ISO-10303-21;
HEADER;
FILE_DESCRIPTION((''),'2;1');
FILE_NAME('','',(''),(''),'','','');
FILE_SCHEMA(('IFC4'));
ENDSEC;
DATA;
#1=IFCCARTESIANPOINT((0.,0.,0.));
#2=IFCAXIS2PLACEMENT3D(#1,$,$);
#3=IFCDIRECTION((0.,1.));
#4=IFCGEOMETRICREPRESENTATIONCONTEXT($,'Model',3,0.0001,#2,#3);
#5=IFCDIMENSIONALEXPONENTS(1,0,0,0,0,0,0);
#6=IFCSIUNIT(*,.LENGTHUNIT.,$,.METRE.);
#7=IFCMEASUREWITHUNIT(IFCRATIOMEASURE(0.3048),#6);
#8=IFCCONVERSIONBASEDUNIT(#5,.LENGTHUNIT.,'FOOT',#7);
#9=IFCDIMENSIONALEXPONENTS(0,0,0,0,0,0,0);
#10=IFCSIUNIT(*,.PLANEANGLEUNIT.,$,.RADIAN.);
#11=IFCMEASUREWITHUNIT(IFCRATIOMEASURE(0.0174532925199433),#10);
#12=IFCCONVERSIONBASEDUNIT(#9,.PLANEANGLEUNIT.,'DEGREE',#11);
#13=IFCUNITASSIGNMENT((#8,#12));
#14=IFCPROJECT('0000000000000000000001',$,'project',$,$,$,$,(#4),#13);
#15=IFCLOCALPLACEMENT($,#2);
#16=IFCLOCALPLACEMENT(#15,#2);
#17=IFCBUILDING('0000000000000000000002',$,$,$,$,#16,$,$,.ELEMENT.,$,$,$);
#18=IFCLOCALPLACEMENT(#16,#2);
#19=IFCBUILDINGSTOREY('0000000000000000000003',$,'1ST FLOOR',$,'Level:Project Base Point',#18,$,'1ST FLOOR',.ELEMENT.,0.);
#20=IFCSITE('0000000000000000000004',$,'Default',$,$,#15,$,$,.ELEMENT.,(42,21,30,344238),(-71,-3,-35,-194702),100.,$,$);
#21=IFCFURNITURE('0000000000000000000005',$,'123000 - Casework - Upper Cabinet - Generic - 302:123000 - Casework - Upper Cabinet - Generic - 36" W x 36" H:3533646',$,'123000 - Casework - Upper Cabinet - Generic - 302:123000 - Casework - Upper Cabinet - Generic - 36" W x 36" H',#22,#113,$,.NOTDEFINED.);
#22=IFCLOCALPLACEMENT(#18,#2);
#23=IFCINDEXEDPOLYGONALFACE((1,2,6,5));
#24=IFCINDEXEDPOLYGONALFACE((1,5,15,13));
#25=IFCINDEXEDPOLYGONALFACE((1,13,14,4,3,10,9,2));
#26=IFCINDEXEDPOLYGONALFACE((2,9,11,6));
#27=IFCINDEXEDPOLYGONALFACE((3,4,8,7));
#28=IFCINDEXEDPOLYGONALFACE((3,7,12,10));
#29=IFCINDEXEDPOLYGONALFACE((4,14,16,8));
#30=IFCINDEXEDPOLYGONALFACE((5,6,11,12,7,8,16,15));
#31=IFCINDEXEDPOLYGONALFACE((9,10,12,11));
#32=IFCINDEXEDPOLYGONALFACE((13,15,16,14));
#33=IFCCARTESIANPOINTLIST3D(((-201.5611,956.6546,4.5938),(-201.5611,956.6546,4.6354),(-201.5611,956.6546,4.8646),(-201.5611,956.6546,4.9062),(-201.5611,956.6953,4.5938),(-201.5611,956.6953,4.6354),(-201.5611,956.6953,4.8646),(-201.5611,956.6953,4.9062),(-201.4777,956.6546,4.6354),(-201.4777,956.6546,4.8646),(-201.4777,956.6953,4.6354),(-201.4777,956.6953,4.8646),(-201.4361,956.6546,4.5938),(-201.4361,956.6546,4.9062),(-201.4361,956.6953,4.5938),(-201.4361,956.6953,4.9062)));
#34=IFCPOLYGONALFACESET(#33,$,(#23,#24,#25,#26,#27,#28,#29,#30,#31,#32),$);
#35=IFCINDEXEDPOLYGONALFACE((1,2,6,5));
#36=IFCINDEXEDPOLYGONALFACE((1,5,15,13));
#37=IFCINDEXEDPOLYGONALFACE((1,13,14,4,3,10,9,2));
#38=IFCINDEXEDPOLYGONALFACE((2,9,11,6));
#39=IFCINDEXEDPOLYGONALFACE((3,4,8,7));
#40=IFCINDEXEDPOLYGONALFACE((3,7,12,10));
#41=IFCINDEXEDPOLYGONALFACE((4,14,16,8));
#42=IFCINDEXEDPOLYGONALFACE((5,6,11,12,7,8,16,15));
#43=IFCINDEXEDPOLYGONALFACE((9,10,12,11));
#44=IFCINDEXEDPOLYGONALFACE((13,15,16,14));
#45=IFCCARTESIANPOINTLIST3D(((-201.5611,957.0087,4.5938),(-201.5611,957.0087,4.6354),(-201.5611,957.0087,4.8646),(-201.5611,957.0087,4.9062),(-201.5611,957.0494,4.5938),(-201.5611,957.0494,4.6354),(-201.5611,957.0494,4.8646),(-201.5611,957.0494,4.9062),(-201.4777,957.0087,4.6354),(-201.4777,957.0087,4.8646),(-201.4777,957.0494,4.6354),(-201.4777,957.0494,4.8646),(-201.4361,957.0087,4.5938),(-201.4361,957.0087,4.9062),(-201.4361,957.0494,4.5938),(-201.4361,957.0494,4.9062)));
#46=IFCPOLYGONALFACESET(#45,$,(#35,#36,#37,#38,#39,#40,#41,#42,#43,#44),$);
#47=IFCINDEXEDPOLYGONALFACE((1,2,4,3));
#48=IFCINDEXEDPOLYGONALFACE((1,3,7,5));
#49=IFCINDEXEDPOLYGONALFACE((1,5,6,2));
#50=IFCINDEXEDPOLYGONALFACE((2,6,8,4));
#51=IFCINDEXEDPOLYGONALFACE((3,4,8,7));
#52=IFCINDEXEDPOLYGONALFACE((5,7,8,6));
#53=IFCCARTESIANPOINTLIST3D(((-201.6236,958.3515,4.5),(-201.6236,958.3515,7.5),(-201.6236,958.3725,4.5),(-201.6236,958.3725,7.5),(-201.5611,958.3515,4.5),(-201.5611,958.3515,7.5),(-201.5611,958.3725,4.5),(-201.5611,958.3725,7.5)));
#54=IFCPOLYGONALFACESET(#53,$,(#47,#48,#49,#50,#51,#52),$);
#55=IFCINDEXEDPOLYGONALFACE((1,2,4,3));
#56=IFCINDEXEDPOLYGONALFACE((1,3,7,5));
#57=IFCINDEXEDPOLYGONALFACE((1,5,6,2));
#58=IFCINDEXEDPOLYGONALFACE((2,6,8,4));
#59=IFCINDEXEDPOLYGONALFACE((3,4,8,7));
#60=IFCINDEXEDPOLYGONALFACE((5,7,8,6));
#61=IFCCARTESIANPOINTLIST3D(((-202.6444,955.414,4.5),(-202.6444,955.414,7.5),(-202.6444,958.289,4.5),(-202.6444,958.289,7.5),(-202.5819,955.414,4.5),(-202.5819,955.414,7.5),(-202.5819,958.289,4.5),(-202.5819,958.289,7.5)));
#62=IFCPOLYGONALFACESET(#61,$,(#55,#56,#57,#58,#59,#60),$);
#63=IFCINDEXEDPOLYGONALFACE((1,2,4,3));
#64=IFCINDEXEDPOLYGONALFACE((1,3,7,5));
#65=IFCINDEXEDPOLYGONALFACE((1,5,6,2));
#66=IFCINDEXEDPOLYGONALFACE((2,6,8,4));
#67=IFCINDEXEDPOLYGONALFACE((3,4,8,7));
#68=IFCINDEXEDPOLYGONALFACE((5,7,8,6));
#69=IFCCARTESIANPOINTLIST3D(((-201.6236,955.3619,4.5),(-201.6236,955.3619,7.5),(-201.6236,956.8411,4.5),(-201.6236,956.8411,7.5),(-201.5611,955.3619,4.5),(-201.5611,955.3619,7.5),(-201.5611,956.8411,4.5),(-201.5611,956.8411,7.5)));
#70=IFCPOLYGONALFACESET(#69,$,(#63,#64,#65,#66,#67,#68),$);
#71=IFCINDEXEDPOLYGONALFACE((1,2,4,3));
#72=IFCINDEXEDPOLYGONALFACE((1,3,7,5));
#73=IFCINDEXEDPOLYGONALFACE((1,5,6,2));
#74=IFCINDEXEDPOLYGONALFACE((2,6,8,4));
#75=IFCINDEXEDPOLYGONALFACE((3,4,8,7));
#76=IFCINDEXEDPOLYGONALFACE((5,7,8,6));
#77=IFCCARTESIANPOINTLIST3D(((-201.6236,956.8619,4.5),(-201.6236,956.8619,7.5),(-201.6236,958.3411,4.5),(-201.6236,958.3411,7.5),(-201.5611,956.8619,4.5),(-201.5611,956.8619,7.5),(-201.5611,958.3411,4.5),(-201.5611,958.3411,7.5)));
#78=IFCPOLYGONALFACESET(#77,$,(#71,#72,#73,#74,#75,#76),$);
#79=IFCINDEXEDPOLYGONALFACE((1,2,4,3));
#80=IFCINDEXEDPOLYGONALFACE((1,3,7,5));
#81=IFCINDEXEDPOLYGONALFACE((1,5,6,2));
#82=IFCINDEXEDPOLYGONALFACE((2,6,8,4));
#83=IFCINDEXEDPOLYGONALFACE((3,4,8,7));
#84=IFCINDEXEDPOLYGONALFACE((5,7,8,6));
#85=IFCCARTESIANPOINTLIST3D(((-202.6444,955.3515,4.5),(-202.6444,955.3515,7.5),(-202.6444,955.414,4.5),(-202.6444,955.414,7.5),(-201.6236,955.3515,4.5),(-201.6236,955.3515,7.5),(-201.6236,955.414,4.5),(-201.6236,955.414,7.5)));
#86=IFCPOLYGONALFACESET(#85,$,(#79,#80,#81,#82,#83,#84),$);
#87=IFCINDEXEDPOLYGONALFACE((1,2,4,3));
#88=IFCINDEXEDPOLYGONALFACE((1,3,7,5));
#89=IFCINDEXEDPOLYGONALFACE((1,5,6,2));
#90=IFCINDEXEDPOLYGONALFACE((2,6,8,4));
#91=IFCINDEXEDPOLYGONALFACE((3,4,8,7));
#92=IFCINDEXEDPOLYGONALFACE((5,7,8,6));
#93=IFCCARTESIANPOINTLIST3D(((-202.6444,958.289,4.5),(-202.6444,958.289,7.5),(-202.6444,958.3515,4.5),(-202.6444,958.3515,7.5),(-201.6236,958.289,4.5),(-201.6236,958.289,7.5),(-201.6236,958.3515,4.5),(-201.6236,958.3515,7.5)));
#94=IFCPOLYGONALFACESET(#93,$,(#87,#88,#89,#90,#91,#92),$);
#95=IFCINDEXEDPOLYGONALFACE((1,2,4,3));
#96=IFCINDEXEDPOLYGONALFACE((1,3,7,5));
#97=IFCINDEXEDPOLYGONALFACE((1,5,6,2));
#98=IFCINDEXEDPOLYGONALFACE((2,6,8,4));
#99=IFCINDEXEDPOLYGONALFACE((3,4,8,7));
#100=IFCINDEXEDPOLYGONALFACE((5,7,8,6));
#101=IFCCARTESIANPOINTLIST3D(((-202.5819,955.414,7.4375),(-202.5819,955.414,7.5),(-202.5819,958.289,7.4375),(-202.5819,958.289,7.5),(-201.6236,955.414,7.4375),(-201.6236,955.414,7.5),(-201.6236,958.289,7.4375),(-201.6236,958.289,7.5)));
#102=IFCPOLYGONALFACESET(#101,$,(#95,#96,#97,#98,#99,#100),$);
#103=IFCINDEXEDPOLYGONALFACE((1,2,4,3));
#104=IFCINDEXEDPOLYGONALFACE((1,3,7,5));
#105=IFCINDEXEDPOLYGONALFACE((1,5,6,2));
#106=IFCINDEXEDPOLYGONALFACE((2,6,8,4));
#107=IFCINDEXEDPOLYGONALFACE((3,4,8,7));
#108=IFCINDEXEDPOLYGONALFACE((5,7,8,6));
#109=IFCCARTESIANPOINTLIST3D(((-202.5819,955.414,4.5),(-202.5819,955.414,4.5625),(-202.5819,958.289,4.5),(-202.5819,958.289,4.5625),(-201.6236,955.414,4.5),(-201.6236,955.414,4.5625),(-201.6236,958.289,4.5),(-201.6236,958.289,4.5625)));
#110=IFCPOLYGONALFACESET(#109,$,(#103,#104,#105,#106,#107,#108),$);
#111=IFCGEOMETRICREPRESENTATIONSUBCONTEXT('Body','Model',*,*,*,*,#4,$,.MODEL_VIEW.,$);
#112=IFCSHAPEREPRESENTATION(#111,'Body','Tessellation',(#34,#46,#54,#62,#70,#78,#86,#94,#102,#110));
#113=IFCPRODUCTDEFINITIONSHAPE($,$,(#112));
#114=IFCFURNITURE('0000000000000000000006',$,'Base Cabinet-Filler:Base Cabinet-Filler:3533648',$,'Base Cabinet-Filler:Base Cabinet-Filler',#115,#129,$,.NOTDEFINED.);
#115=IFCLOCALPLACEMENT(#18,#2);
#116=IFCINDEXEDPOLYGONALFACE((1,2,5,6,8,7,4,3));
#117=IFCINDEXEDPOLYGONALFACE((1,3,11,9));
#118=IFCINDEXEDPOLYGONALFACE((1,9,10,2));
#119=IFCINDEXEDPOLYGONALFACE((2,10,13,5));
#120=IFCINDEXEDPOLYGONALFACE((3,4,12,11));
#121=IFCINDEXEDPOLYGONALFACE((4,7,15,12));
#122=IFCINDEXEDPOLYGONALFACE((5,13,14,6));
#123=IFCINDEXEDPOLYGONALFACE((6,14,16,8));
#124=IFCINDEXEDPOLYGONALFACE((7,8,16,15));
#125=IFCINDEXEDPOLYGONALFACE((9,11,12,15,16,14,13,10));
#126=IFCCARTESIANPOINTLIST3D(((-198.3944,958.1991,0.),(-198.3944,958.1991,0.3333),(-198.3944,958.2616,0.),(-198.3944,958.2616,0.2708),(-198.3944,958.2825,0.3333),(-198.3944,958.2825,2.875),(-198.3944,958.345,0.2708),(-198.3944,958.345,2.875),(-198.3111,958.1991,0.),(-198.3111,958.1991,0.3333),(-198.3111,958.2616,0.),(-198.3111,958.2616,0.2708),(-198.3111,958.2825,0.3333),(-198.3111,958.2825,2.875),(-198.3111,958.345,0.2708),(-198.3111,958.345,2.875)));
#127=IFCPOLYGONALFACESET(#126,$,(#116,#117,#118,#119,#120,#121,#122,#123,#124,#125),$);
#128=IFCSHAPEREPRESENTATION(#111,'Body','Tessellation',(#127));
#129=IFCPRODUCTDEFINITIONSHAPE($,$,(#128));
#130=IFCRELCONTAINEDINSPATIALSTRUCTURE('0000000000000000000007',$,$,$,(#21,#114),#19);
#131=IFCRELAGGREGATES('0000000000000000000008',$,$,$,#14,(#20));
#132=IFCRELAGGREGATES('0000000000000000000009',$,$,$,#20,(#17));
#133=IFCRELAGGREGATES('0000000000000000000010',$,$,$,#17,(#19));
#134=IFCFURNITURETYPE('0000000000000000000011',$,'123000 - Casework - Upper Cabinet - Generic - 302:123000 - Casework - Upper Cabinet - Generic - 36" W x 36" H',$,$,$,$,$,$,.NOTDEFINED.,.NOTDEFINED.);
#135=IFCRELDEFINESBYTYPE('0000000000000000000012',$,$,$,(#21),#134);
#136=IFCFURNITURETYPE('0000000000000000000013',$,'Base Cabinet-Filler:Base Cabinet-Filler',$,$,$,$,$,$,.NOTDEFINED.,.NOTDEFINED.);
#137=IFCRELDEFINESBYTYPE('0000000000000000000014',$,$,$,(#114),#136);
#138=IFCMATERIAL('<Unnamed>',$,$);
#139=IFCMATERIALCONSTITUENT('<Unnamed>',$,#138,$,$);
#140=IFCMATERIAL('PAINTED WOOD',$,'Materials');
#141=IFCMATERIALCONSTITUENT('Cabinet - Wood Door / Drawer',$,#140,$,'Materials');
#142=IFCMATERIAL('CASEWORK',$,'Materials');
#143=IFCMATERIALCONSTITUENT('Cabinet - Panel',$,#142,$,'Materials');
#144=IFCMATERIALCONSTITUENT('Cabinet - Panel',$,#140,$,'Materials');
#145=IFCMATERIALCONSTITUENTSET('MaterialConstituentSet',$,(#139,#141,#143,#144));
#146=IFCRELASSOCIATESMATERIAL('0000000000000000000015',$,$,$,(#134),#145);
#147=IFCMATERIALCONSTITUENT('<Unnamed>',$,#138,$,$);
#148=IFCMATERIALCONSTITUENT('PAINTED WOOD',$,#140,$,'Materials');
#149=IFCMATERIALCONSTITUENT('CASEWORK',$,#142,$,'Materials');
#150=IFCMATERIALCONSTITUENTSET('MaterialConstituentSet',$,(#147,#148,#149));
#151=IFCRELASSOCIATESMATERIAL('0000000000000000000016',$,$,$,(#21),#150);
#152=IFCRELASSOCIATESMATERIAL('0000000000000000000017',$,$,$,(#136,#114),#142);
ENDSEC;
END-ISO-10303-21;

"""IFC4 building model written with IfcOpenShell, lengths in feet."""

from ifc_helpers import new_model, entity, si_unit, converted_unit, direction, frame, frame_2d, origin, origin_2d_with_axis, place, context, subcontext, project, spatial, polyline, rectangle, outline, extrude, source, transform, mapped, material, constituent, constituent_set, type_object, type_shapes, element, save


model = new_model("IFC4")

# Units and contexts
model_context = context("Model", 3, precision=0.0001, world=origin(), true_north=direction((0.0, 1.0)))
body_context = subcontext(model_context, "Body", "Model", "MODEL_VIEW")
ifc_project = project(units=[converted_unit("LENGTHUNIT", "FOOT", entity("IfcRatioMeasure", 0.3048), si_unit("LENGTHUNIT", "METRE"), dimensions=[1, 0, 0, 0, 0, 0, 0]), converted_unit("PLANEANGLEUNIT", "DEGREE", entity("IfcRatioMeasure", 0.0174532925199433), si_unit("PLANEANGLEUNIT", "RADIAN"), dimensions=[0, 0, 0, 0, 0, 0, 0])], contexts=[model_context])

# Site, building, storey
site_placement = place(None, origin())
site = spatial("IfcSite", under=ifc_project, at=site_placement, Name="Default", CompositionType="ELEMENT", RefLatitude=(42, 21, 30, 344238), RefLongitude=(-71, -3, -35, -194702), RefElevation=100.0)
building_placement = place(site_placement, origin())
building = spatial("IfcBuilding", under=site, at=building_placement, CompositionType="ELEMENT")
storey_placement = place(building_placement, origin())
storey = spatial("IfcBuildingStorey", under=building, at=storey_placement, Name="1ST FLOOR", ObjectType="Level:Project Base Point", LongName="1ST FLOOR", CompositionType="ELEMENT", Elevation=0.0)

# Shared definitions
ifc_material_1 = material(Name="<Unnamed>")

# Shared definitions
ifc_material_2 = material(Name="PAINTED WOOD", Category="Materials")
ifc_material_3 = material(Name="CASEWORK", Category="Materials")

# Furniture
ifc_constituent_1 = constituent(ifc_material_1, Name="<Unnamed>")
ifc_constituent_2 = constituent(ifc_material_2, Name="PAINTED WOOD", Category="Materials")
ifc_constituent_3 = constituent(ifc_material_3, Name="CASEWORK", Category="Materials")
ifc_constituent_set_1 = constituent_set(constituents=[ifc_constituent_1, ifc_constituent_2, ifc_constituent_3], Name="MaterialConstituentSet")
ifc_constituent_4 = constituent(ifc_material_1, Name="<Unnamed>")
ifc_constituent_5 = constituent(ifc_material_2, Name="Cabinet - Wood Door / Drawer", Category="Materials")
ifc_constituent_6 = constituent(ifc_material_3, Name="Cabinet - Panel", Category="Materials")
ifc_constituent_7 = constituent(ifc_material_2, Name="Cabinet - Panel", Category="Materials")
ifc_constituent_set_2 = constituent_set(constituents=[ifc_constituent_4, ifc_constituent_5, ifc_constituent_6, ifc_constituent_7], Name="MaterialConstituentSet")
furniture_type_1 = type_object("IfcFurnitureType", Name="123000 - Casework - Upper Cabinet - Generic - 302:123000 - Casework - Upper Cabinet - Generic - 36\" W x 36\" H", AssemblyPlace="NOTDEFINED", PredefinedType="NOTDEFINED", material=ifc_constituent_set_2)
shared_shape_1 = source(origin(), body_context, "Body", "SweptSolid", [
    extrude(outline(polyline([(0.1146, -0.0521), (0.1562, -0.0521), (0.1562, 0.0729), (-0.1562, 0.0729), (-0.1562, -0.0521), (-0.1146, -0.0521), (-0.1146, 0.0313), (0.1146, 0.0313), (0.1146, -0.0521)])), frame((1.303, 0.0729, 0.25), z_axis=(1.0, 0.0, 0.0), x_axis=(0.0, 0.0, 1.0)), (0.0, 0.0, 1.0), 0.0407),
    extrude(outline(polyline([(0.1146, -0.0521), (0.1562, -0.0521), (0.1562, 0.0729), (-0.1562, 0.0729), (-0.1562, -0.0521), (-0.1146, -0.0521), (-0.1146, 0.0313), (0.1146, 0.0313), (0.1146, -0.0521)])), frame((1.6572, 0.0729, 0.25), z_axis=(1.0, 0.0, 0.0), x_axis=(0.0, 0.0, 1.0)), (0.0, 0.0, 1.0), 0.0407),
    extrude(rectangle(XDim=0.0625, YDim=0.021, at=frame_2d((0.0, 0.0), x_axis=(1.0, 0.0))), frame((3.0105, 0.1562, 0.0), z_axis=(0.0, 0.0, 1.0), x_axis=(0.0, -1.0, 0.0)), (0.0, 0.0, 1.0), 3.0),
    extrude(rectangle(XDim=0.0625, YDim=2.875, at=origin_2d_with_axis()), frame((1.5, 1.177, 0.0), z_axis=(0.0, 0.0, 1.0), x_axis=(0.0, 1.0, 0.0)), (0.0, 0.0, 1.0), 3.0),
    extrude(rectangle(XDim=0.0625, YDim=1.4792, at=frame_2d((0.0, 0.0), x_axis=(1.0, 0.0))), frame((0.75, 0.1562, 0.0), z_axis=(0.0, 0.0, 1.0), x_axis=(0.0, -1.0, 0.0)), (0.0, 0.0, 1.0), 3.0),
    extrude(rectangle(XDim=0.0625, YDim=1.4792, at=origin_2d_with_axis()), frame((2.25, 0.1562, 0.0), z_axis=(0.0, 0.0, 1.0), x_axis=(0.0, -1.0, 0.0)), (0.0, 0.0, 1.0), 3.0),
    extrude(rectangle(XDim=0.0625, YDim=1.0208, at=origin_2d_with_axis()), frame((0.0312, 0.6979, 0.0), z_axis=(0.0, 0.0, 1.0), x_axis=(-1.0, 0.0, 0.0)), (0.0, 0.0, 1.0), 3.0),
    extrude(rectangle(XDim=0.0625, YDim=1.0208, at=origin_2d_with_axis()), frame((2.9688, 0.6979, 0.0), z_axis=(0.0, 0.0, 1.0), x_axis=(-1.0, 0.0, 0.0)), (0.0, 0.0, 1.0), 3.0),
    extrude(rectangle(XDim=2.875, YDim=0.9583, at=frame_2d((0.0, 0.0), x_axis=(1.0, 0.0))), frame((1.5, 0.6666, 2.9375), z_axis=(0.0, 0.0, 1.0), x_axis=(-1.0, 0.0, 0.0)), (0.0, 0.0, 1.0), 0.0625),
    extrude(rectangle(XDim=2.875, YDim=0.9583, at=frame_2d((0.0, 0.0), x_axis=(1.0, 0.0))), frame((1.5, 0.6666, 0.0), z_axis=(0.0, 0.0, 1.0), x_axis=(-1.0, 0.0, 0.0)), (0.0, 0.0, 1.0), 0.0625),
])
type_shapes(furniture_type_1, [shared_shape_1])
furniture_1_placement = place(storey_placement, frame((-201.4361, 955.3515, 4.5), z_axis=(0.0, 0.0, 1.0), x_axis=(0.0, 1.0, 0.0)))
element("IfcFurniture", 1, at=furniture_1_placement, inside=storey, type_object=furniture_type_1, material=ifc_constituent_set_1, Name="123000 - Casework - Upper Cabinet - Generic - 302:123000 - Casework - Upper Cabinet - Generic - 36\" W x 36\" H:3533646", ObjectType="123000 - Casework - Upper Cabinet - Generic - 302:123000 - Casework - Upper Cabinet - Generic - 36\" W x 36\" H", PredefinedType="NOTDEFINED", context=body_context, shape_type="MappedRepresentation", body=[
    mapped(shared_shape_1, transform((0.0, 0.0, 0.0), scale=1.0)),
])
furniture_type_2 = type_object("IfcFurnitureType", Name="Base Cabinet-Filler:Base Cabinet-Filler", AssemblyPlace="NOTDEFINED", PredefinedType="NOTDEFINED", material=ifc_material_3)
shared_shape_2 = source(origin(), body_context, "Body", "SweptSolid", [
    extrude(outline(polyline([(-0.0729, 0.599), (-0.0729, -2.0052), (-0.0104, -2.0052), (-0.0104, 0.5365), (0.0729, 0.5365), (0.0729, 0.8698), (0.0104, 0.8698), (0.0104, 0.599), (-0.0729, 0.599)])), frame((0.0, 0.0729, 0.8698), z_axis=(-1.0, 0.0, 0.0), x_axis=(0.0, 1.0, 0.0)), (0.0, 0.0, -1.0), 0.0833),
])
type_shapes(furniture_type_2, [shared_shape_2])
furniture_2_placement = place(storey_placement, frame((-198.3111, 958.345, 0.0), z_axis=(0.0, 0.0, 1.0), x_axis=(-1.0, 0.0, 0.0)))
element("IfcFurniture", 2, at=furniture_2_placement, inside=storey, type_object=furniture_type_2, material=ifc_material_3, Name="Base Cabinet-Filler:Base Cabinet-Filler:3533648", ObjectType="Base Cabinet-Filler:Base Cabinet-Filler", PredefinedType="NOTDEFINED", context=body_context, shape_type="MappedRepresentation", body=[
    mapped(shared_shape_2, transform((0.0, 0.0, 0.0), scale=1.0)),
])

save(model, "model.ifc")
